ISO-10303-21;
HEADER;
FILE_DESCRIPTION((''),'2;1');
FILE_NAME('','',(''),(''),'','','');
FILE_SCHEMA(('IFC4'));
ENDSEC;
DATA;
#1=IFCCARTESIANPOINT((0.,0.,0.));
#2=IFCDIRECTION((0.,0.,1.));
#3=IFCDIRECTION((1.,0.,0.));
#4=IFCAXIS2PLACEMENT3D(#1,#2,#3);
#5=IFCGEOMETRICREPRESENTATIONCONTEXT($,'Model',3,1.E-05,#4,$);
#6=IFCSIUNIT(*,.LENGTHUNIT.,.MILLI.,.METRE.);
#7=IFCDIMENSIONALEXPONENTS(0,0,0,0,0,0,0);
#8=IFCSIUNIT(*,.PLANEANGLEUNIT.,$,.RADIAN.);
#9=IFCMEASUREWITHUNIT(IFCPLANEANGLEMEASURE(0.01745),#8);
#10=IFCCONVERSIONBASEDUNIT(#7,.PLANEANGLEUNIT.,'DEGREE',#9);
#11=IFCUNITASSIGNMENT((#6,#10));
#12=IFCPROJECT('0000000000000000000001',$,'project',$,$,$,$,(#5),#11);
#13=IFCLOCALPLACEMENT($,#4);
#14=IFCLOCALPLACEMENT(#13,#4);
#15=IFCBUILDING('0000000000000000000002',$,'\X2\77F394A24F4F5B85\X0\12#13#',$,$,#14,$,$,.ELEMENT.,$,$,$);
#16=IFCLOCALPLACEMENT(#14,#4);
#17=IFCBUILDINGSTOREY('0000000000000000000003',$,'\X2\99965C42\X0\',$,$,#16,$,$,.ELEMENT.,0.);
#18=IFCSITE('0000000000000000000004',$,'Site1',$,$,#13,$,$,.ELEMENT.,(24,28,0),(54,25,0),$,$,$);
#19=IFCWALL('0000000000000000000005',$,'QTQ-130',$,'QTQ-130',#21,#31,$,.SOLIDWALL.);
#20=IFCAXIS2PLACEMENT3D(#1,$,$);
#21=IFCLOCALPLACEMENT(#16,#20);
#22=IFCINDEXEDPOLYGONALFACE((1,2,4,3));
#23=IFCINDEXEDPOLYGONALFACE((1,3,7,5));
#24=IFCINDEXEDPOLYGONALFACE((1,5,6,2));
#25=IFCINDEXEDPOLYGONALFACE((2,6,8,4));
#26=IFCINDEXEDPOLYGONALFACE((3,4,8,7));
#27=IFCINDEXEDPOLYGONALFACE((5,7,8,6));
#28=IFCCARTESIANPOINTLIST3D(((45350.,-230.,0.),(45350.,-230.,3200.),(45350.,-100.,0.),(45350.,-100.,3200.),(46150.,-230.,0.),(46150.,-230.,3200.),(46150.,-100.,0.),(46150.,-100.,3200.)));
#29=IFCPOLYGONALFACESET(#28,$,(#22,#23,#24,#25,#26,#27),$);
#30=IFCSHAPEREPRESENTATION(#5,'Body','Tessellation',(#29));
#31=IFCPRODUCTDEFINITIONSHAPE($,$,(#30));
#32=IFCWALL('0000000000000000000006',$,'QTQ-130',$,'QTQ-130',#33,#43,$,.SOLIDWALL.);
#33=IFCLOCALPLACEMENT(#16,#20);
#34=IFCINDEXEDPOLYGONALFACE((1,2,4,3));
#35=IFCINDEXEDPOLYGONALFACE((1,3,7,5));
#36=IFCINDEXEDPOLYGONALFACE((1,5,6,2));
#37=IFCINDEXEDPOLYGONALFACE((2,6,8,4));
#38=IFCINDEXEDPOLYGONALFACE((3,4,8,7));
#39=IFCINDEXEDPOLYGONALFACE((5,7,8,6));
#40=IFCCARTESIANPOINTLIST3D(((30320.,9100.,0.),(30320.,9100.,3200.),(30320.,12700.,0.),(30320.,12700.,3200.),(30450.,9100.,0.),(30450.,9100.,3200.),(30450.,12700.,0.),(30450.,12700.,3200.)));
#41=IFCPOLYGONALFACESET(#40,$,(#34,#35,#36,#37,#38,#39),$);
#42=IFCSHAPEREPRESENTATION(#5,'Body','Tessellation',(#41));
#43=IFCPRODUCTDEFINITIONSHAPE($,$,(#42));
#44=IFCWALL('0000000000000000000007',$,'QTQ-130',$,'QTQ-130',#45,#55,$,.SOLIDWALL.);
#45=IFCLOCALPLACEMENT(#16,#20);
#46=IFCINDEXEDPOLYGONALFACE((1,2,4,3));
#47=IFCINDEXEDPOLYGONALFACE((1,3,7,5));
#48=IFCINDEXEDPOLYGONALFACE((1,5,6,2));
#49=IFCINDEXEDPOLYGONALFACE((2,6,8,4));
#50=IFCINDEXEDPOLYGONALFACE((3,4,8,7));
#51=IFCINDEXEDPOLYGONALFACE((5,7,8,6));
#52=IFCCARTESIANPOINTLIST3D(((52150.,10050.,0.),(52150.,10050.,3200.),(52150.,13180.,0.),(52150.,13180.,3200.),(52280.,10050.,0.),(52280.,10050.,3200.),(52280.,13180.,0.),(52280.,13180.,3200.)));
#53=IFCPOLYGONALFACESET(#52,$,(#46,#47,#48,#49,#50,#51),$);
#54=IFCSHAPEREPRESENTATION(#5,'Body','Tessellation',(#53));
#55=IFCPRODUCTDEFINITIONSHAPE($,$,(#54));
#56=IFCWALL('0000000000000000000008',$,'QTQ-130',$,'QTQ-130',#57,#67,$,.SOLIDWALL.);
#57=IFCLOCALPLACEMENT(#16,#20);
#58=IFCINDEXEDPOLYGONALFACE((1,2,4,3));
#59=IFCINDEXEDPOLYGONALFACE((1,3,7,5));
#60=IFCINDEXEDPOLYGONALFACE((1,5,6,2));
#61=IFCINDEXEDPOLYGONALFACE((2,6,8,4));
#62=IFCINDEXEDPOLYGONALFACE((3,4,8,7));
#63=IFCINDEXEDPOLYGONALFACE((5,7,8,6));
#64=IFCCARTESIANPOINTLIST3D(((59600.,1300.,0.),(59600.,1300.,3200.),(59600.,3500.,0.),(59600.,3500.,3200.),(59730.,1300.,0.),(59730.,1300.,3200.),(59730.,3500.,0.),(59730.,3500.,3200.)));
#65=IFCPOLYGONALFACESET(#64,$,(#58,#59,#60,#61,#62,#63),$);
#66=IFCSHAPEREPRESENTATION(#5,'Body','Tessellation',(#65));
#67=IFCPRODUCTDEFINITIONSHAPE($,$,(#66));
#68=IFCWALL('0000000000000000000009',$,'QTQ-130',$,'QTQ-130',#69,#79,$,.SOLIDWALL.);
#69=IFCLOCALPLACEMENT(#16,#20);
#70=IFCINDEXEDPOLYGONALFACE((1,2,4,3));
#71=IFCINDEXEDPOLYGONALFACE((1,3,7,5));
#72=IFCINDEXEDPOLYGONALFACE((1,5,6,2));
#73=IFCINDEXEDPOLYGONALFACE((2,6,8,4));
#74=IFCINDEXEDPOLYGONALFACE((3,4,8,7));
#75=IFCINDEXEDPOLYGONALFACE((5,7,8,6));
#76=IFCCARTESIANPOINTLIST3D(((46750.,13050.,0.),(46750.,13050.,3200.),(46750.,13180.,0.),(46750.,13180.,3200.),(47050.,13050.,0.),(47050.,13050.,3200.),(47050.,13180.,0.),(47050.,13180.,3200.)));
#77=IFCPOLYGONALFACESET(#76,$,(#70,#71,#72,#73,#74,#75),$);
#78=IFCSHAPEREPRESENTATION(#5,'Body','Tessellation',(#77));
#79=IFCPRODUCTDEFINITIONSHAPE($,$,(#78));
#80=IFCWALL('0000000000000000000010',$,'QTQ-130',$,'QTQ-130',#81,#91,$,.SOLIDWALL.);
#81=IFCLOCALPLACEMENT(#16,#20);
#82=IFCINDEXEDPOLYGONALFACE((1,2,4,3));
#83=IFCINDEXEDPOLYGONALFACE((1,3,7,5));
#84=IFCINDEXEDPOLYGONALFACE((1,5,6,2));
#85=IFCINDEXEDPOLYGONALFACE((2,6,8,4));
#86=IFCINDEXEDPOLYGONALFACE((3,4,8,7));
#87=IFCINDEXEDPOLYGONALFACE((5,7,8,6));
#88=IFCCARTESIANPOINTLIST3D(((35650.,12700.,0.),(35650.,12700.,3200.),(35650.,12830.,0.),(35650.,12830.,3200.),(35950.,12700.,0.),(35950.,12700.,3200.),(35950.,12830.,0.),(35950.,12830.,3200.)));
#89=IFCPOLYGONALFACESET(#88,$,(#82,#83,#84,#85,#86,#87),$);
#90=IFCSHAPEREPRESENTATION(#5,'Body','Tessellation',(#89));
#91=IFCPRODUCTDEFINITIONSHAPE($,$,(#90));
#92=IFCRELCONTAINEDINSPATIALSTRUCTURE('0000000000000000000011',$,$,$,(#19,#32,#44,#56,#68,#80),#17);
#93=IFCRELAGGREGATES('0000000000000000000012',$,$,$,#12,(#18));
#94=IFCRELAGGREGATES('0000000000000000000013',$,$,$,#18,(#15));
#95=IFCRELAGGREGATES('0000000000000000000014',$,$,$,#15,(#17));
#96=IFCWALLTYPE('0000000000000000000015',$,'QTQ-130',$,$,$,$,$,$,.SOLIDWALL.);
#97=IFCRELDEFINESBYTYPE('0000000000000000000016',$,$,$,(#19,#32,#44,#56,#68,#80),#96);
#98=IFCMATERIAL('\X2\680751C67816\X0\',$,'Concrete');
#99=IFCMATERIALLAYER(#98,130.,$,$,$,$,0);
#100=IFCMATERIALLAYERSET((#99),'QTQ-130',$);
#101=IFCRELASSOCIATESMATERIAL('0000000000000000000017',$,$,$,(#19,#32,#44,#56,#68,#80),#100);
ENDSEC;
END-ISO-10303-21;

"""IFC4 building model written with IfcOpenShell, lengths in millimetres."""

from ifc_helpers import new_model, entity, si_unit, converted_unit, frame, origin_with_axes, place, context, project, spatial, polyline, outline, extrude, material, layer, layer_set, type_object, element, save


model = new_model("IFC4")

# Units and contexts
model_context = context("Model", 3, precision=1e-05, world=origin_with_axes())
ifc_project = project(units=[si_unit("LENGTHUNIT", "METRE", prefix="MILLI"), converted_unit("PLANEANGLEUNIT", "DEGREE", entity("IfcPlaneAngleMeasure", 0.01745), si_unit("PLANEANGLEUNIT", "RADIAN"), dimensions=[0, 0, 0, 0, 0, 0, 0])], contexts=[model_context])

# Site, building, storey
site_placement = place(None, origin_with_axes())
site = spatial("IfcSite", under=ifc_project, at=site_placement, Name="Site1", CompositionType="ELEMENT", RefLatitude=(24, 28, 0), RefLongitude=(54, 25, 0))
building_placement = place(site_placement, origin_with_axes())
building = spatial("IfcBuilding", under=site, at=building_placement, Name="石钢住宅12#13#", CompositionType="ELEMENT")
storey_placement = place(building_placement, origin_with_axes())
storey = spatial("IfcBuildingStorey", under=building, at=storey_placement, Name="首层", CompositionType="ELEMENT", Elevation=0.0)

# Walls
ifc_material_1 = material(Name="标准砖", Category="Concrete")
ifc_layer_1 = layer(ifc_material_1, 130.0, Priority=0)
ifc_layer_set_1 = layer_set([ifc_layer_1], Name="QTQ-130")
wall_type = type_object("IfcWallType", Name="QTQ-130", PredefinedType="SOLIDWALL")
wall_1_placement = place(storey_placement, origin_with_axes())
element("IfcWall", 1, at=wall_1_placement, inside=storey, type_object=wall_type, material=ifc_layer_set_1, Name="QTQ-130", ObjectType="QTQ-130", PredefinedType="SOLIDWALL", context=model_context, shape_type="SweptSolid", body=[
    extrude(outline(polyline([(0.0, 0.0), (3200.0, 0.0), (3200.0, 800.0), (0.0, 800.0), (0.0, 0.0)])), frame((46150.0, -230.0, 3200.0), z_axis=(0.0, 1.0, 0.0), x_axis=(0.0, 0.0, -1.0)), (0.0, 0.0, 1.0), 130.0),
])
wall_2_placement = place(storey_placement, origin_with_axes())
element("IfcWall", 2, at=wall_2_placement, inside=storey, type_object=wall_type, material=ifc_layer_set_1, Name="QTQ-130", ObjectType="QTQ-130", PredefinedType="SOLIDWALL", context=model_context, shape_type="SweptSolid", body=[
    extrude(outline(polyline([(0.0, 0.0), (3200.0, 0.0), (3200.0, 3600.0), (0.0, 3600.0), (0.0, 0.0)])), frame((30320.0, 9100.0, 3200.0), z_axis=(1.0, 0.0, 0.0), x_axis=(0.0, 0.0, -1.0)), (0.0, 0.0, 1.0), 130.0),
])
wall_3_placement = place(storey_placement, origin_with_axes())
element("IfcWall", 3, at=wall_3_placement, inside=storey, type_object=wall_type, material=ifc_layer_set_1, Name="QTQ-130", ObjectType="QTQ-130", PredefinedType="SOLIDWALL", context=model_context, shape_type="SweptSolid", body=[
    extrude(outline(polyline([(0.0, 0.0), (3200.0, 0.0), (3200.0, 3130.0), (0.0, 3130.0), (0.0, 0.0)])), frame((52280.0, 13180.0, 3200.0), z_axis=(-1.0, 0.0, 0.0), x_axis=(0.0, 0.0, -1.0)), (0.0, 0.0, 1.0), 130.0),
])
wall_4_placement = place(storey_placement, origin_with_axes())
element("IfcWall", 4, at=wall_4_placement, inside=storey, type_object=wall_type, material=ifc_layer_set_1, Name="QTQ-130", ObjectType="QTQ-130", PredefinedType="SOLIDWALL", context=model_context, shape_type="SweptSolid", body=[
    extrude(outline(polyline([(0.0, 0.0), (3200.0, 0.0), (3200.0, 2200.0), (0.0, 2200.0), (0.0, 0.0)])), frame((59730.0, 3500.0, 3200.0), z_axis=(-1.0, 0.0, 0.0), x_axis=(0.0, 0.0, -1.0)), (0.0, 0.0, 1.0), 130.0),
])
wall_5_placement = place(storey_placement, origin_with_axes())
element("IfcWall", 5, at=wall_5_placement, inside=storey, type_object=wall_type, material=ifc_layer_set_1, Name="QTQ-130", ObjectType="QTQ-130", PredefinedType="SOLIDWALL", context=model_context, shape_type="SweptSolid", body=[
    extrude(outline(polyline([(0.0, 0.0), (3200.0, 0.0), (3200.0, 300.0), (0.0, 300.0), (0.0, 0.0)])), frame((46750.0, 13180.0, 3200.0), z_axis=(0.0, -1.0, 0.0), x_axis=(0.0, 0.0, -1.0)), (0.0, 0.0, 1.0), 130.0),
])
wall_6_placement = place(storey_placement, origin_with_axes())
element("IfcWall", 6, at=wall_6_placement, inside=storey, type_object=wall_type, material=ifc_layer_set_1, Name="QTQ-130", ObjectType="QTQ-130", PredefinedType="SOLIDWALL", context=model_context, shape_type="SweptSolid", body=[
    extrude(outline(polyline([(0.0, 0.0), (3200.0, 0.0), (3200.0, 300.0), (0.0, 300.0), (0.0, 0.0)])), frame((35650.0, 12830.0, 3200.0), z_axis=(0.0, -1.0, 0.0), x_axis=(0.0, 0.0, -1.0)), (0.0, 0.0, 1.0), 130.0),
])

save(model, "model.ifc")
